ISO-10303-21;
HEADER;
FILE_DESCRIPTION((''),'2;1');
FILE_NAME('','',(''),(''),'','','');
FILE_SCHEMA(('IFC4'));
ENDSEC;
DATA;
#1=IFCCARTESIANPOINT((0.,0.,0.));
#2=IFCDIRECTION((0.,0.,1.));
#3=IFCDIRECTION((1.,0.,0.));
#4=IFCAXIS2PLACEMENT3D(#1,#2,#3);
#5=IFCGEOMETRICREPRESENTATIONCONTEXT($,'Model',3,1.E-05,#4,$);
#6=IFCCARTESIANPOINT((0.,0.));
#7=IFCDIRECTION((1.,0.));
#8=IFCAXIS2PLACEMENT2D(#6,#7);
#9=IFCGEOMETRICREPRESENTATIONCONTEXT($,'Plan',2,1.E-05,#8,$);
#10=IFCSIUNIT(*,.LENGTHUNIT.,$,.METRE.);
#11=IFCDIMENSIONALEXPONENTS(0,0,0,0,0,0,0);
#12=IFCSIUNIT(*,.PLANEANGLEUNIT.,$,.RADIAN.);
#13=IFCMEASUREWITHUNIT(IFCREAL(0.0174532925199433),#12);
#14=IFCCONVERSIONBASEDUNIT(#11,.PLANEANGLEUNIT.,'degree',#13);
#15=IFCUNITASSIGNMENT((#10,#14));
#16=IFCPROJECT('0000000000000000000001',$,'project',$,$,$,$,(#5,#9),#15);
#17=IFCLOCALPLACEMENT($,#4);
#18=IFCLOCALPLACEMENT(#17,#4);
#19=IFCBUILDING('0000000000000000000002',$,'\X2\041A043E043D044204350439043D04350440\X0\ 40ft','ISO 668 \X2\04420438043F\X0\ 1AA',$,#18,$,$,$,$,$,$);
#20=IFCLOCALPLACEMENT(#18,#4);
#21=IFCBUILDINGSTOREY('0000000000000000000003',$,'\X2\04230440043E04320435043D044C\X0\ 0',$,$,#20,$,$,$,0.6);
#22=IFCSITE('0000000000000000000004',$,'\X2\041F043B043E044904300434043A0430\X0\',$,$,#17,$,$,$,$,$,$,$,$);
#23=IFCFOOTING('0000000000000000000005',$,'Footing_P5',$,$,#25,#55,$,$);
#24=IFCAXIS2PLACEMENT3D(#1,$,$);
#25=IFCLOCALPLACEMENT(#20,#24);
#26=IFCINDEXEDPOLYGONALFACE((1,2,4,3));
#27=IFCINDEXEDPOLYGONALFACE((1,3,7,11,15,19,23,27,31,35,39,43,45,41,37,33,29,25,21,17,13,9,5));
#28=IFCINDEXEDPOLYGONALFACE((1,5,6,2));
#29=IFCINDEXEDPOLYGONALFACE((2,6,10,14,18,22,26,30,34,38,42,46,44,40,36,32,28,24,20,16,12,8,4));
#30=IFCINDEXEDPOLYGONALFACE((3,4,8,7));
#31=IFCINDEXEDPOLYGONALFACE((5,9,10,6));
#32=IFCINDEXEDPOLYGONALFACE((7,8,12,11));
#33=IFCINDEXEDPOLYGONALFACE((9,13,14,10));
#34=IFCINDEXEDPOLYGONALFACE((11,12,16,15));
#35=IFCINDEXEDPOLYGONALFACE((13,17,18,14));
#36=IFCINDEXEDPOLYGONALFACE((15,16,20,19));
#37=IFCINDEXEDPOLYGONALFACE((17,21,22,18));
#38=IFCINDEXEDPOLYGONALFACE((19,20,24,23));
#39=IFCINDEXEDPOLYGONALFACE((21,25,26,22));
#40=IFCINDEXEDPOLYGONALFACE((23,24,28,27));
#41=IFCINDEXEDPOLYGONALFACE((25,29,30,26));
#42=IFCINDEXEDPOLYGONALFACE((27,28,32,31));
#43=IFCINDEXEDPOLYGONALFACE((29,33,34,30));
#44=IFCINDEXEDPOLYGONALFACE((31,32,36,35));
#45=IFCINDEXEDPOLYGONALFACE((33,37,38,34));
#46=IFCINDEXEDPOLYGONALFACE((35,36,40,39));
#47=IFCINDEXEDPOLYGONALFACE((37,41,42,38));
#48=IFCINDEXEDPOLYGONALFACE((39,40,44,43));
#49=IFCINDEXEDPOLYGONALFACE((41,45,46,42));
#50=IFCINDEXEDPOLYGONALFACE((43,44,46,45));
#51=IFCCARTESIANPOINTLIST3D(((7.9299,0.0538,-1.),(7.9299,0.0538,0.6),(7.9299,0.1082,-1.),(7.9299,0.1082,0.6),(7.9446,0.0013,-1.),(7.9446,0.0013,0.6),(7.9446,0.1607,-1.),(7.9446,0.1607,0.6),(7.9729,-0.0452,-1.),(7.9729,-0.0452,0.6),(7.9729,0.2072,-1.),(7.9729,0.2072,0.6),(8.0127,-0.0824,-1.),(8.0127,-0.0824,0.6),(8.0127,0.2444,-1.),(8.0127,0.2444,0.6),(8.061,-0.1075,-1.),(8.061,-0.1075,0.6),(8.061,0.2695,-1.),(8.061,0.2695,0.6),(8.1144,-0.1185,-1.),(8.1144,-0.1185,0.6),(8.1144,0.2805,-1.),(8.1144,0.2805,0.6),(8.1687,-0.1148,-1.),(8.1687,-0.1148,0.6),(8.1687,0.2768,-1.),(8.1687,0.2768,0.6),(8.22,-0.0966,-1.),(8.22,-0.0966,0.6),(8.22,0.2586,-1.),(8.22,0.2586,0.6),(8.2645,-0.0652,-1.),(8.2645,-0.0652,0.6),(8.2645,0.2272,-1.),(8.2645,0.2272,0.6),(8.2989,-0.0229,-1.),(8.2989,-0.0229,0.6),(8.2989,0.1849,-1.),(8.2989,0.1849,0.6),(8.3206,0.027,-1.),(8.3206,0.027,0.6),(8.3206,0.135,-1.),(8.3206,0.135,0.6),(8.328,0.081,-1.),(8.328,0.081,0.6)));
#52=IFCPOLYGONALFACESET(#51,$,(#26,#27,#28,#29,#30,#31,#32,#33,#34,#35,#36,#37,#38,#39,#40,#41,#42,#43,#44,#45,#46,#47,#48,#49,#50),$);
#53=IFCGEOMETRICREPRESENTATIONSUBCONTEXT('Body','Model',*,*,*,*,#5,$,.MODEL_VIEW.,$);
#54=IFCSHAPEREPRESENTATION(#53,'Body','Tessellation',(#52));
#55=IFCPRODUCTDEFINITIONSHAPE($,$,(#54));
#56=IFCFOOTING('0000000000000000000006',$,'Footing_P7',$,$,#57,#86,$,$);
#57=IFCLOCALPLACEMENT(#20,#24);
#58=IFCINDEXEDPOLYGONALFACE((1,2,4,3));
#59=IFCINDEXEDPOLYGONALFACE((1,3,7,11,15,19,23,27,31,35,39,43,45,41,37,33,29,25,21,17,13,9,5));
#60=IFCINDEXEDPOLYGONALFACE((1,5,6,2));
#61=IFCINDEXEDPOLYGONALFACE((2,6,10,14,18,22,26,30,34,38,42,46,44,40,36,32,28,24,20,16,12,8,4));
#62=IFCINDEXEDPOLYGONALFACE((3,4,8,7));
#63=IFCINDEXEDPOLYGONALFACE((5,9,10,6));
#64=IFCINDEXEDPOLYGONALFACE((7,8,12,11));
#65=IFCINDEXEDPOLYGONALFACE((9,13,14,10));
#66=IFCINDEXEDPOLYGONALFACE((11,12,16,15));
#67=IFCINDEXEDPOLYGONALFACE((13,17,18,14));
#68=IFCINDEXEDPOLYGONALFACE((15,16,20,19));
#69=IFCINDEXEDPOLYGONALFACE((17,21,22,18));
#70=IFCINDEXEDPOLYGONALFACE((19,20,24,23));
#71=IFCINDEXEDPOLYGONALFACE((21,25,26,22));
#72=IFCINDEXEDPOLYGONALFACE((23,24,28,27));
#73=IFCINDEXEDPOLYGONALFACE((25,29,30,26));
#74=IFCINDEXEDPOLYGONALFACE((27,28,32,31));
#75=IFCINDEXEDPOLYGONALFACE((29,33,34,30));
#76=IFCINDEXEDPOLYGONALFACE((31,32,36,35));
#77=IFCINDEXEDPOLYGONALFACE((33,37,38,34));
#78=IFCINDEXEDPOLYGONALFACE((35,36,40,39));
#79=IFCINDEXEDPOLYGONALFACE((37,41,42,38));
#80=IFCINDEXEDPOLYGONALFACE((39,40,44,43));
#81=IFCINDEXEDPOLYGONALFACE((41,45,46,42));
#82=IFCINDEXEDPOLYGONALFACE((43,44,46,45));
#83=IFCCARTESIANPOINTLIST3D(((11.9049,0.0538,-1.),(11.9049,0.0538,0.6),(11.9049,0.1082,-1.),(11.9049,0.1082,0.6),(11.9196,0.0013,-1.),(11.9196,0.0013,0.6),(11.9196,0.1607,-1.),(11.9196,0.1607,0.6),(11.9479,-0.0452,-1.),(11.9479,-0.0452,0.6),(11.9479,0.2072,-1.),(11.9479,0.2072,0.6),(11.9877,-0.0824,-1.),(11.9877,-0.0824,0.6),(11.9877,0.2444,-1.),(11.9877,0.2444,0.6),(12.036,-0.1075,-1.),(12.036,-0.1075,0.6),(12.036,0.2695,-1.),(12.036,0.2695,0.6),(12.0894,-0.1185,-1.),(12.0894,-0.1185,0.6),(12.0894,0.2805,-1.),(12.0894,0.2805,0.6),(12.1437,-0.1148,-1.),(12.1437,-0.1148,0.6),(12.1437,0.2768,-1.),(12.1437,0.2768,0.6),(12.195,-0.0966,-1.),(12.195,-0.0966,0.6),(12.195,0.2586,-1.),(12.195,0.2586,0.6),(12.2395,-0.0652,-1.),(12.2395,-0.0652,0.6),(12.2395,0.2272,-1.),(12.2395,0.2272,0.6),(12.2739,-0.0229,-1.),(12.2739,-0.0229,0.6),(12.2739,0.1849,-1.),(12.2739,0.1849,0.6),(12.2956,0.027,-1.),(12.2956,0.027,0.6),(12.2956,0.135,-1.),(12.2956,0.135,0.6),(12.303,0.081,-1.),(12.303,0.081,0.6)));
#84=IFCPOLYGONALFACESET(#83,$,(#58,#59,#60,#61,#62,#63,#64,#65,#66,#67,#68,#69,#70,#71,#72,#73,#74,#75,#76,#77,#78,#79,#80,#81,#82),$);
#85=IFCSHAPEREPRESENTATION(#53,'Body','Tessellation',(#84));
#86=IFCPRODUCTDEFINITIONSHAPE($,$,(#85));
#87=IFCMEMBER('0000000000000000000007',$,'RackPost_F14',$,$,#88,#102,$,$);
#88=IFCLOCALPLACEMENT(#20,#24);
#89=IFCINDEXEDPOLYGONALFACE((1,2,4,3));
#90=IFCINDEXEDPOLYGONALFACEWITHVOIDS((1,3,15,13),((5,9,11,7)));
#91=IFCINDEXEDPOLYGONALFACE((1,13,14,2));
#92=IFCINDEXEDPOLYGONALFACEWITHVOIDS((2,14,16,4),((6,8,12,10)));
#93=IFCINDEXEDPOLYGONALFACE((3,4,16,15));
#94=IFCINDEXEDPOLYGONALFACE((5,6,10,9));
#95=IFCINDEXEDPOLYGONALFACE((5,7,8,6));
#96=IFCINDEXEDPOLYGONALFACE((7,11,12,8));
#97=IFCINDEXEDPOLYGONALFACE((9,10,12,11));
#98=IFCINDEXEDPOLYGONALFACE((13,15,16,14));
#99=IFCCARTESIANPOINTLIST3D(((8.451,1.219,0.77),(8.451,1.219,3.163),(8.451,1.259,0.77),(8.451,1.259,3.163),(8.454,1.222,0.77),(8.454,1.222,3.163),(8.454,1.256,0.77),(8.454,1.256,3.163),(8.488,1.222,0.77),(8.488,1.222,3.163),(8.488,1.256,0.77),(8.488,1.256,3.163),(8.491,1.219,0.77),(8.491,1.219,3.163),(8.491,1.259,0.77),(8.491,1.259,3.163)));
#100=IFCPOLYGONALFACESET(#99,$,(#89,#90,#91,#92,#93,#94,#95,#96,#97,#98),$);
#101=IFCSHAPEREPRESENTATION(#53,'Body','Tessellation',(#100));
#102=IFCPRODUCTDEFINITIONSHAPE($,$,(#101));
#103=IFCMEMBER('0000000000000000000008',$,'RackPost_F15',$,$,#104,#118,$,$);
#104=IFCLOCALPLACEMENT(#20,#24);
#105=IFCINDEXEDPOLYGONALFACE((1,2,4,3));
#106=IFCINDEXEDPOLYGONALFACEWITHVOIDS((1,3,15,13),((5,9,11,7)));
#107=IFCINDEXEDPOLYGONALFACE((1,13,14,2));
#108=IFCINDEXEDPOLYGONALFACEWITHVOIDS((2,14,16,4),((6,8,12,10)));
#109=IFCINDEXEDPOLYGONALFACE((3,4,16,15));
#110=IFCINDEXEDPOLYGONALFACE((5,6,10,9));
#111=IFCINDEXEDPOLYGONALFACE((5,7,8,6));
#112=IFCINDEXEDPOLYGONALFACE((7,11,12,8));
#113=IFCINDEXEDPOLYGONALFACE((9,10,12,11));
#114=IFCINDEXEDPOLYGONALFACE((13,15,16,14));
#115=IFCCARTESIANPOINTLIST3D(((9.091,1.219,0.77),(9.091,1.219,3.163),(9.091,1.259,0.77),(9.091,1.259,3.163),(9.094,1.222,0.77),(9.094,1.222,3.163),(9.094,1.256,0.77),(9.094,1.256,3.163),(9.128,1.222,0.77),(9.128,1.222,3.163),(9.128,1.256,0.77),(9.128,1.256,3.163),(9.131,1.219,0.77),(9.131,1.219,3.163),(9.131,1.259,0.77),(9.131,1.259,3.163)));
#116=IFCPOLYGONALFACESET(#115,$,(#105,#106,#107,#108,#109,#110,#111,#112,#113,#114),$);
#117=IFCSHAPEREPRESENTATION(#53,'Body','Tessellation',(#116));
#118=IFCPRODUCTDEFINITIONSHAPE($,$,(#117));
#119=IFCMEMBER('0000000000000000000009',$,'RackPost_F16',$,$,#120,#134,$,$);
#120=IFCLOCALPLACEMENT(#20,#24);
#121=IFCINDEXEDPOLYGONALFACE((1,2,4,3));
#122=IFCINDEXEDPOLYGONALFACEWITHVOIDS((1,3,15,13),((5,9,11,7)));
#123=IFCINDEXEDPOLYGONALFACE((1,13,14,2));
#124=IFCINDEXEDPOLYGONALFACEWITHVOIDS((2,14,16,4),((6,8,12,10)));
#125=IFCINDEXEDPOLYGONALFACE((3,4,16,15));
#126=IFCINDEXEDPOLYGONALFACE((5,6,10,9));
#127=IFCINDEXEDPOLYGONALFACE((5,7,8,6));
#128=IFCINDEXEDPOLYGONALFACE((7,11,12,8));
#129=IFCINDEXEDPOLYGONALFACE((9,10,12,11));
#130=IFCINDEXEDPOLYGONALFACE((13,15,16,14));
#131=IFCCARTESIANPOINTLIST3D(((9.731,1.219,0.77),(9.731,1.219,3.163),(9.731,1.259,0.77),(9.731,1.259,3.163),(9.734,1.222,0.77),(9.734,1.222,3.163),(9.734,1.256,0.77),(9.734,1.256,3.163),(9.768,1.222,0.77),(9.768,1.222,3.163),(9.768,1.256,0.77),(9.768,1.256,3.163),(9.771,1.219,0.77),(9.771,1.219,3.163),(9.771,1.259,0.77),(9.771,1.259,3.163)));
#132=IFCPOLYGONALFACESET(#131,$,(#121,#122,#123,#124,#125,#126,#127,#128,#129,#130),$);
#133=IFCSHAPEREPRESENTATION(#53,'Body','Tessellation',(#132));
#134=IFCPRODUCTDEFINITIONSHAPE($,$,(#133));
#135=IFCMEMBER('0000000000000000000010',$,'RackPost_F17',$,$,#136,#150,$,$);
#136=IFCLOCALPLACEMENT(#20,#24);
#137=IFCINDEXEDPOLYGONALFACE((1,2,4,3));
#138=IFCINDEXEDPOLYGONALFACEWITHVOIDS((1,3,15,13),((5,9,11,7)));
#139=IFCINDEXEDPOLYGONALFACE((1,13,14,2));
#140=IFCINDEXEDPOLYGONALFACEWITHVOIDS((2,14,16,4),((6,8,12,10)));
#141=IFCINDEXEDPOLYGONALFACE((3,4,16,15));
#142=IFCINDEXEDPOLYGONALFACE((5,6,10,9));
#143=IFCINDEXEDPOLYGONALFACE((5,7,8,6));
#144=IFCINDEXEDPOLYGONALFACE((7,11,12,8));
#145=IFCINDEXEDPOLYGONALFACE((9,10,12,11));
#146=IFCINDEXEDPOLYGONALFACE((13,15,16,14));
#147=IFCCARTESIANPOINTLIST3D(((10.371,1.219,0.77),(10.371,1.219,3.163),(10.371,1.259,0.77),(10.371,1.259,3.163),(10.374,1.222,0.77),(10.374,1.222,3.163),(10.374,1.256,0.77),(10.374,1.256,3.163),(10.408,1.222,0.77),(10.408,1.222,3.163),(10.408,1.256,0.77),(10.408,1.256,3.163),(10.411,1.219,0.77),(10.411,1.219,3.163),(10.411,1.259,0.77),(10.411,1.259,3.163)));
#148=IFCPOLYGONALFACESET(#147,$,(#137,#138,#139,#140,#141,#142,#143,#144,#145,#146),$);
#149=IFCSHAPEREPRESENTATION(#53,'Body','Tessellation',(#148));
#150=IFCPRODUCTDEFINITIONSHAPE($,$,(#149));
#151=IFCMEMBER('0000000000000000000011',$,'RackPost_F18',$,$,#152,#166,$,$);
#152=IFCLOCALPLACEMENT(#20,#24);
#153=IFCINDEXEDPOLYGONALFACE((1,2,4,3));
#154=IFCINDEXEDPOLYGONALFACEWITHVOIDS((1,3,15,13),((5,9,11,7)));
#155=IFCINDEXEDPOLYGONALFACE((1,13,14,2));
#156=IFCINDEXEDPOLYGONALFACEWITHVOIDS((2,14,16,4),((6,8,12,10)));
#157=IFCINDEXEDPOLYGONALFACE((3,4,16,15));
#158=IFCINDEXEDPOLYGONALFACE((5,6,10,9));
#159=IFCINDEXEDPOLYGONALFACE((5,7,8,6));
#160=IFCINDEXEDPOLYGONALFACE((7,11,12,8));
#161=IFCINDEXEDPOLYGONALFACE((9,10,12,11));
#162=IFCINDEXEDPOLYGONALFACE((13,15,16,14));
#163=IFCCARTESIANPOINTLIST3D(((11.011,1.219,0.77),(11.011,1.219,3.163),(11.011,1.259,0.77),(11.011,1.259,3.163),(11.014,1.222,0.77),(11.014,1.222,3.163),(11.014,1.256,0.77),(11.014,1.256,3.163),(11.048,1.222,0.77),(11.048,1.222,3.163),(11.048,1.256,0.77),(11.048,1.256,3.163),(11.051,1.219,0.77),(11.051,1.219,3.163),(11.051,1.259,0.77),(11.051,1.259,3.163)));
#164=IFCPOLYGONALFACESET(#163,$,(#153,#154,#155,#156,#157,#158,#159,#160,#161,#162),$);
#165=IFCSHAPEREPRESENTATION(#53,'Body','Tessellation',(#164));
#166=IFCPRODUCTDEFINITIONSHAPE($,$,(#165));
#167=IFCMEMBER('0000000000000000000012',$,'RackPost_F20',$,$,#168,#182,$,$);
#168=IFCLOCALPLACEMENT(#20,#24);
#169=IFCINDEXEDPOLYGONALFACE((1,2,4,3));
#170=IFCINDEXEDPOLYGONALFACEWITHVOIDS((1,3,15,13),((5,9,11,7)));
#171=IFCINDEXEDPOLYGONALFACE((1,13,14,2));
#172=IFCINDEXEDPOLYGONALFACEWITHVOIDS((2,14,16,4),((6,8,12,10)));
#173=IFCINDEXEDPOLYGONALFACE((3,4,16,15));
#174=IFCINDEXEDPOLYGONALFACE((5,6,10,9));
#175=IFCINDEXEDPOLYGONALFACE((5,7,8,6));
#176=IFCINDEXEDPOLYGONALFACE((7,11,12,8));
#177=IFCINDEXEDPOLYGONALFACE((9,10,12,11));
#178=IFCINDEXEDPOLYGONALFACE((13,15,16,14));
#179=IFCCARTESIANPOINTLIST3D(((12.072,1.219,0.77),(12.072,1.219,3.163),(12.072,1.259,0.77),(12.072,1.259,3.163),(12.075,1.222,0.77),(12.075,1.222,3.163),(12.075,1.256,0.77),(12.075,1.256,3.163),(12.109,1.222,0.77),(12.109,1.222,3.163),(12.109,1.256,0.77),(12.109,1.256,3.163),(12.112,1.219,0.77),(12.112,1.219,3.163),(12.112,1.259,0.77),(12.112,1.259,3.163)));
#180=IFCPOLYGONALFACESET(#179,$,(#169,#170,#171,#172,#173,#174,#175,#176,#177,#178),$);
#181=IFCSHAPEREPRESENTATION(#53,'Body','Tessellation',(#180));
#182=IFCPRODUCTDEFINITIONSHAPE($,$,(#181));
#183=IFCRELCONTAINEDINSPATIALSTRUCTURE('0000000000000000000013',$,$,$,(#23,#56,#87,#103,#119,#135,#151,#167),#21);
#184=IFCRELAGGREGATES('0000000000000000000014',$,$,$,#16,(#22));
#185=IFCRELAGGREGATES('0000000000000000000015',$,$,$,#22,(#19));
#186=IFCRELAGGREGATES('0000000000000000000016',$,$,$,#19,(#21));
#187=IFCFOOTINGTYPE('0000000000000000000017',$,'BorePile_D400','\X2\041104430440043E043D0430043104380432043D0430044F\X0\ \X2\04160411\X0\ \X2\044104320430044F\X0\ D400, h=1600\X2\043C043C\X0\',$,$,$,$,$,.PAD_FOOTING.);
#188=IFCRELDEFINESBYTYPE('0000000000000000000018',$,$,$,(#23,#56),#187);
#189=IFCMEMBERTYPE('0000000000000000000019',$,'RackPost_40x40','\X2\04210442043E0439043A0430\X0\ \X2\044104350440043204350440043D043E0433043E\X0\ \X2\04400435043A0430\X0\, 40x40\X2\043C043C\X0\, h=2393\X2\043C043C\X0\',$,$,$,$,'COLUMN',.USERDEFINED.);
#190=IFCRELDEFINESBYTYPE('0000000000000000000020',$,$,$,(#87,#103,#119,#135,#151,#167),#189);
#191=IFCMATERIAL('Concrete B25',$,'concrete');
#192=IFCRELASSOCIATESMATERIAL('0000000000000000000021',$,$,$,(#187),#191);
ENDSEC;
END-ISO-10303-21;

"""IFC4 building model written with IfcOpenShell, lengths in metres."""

from ifc_helpers import new_model, entity, si_unit, converted_unit, frame, origin_with_axes, origin_2d_with_axis, place, context, subcontext, project, spatial, hollow_rectangle, circle, extrude, material, type_object, element, save


model = new_model("IFC4")

# Units and contexts
model_context = context("Model", 3, precision=1e-05, world=origin_with_axes())
plan_context = context("Plan", 2, precision=1e-05, world=origin_2d_with_axis())
body_context = subcontext(model_context, "Body", "Model", "MODEL_VIEW")
ifc_project = project(units=[si_unit("LENGTHUNIT", "METRE"), converted_unit("PLANEANGLEUNIT", "degree", entity("IfcReal", 0.0174532925199433), si_unit("PLANEANGLEUNIT", "RADIAN"), dimensions=[0, 0, 0, 0, 0, 0, 0])], contexts=[model_context, plan_context])

# Site, building, storey
site_placement = place(None, origin_with_axes())
site = spatial("IfcSite", under=ifc_project, at=site_placement, Name="Площадка")
building_placement = place(site_placement, origin_with_axes())
building = spatial("IfcBuilding", under=site, at=building_placement, Name="Контейнер 40ft", Description="ISO 668 тип 1AA")
storey_placement = place(building_placement, origin_with_axes())
storey = spatial("IfcBuildingStorey", under=building, at=storey_placement, Name="Уровень 0", Elevation=0.6)

# Footings
ifc_material = material(Name="Concrete B25", Category="concrete")
footing_type = type_object("IfcFootingType", Name="BorePile_D400", Description="Буронабивная ЖБ свая D400, h=1600мм", PredefinedType="PAD_FOOTING", material=ifc_material)
for number, where, z_axis, x_axis, name in (
    (1, (8.128, 0.081, -1.0), (0.0, 0.0, 1.0), (1.0, 0.0, 0.0), "Footing_P5"),
    (2, (12.103, 0.081, -1.0), (0.0, 0.0, 1.0), (1.0, 0.0, 0.0), "Footing_P7"),
):
    element("IfcFooting", number, at=place(storey_placement, frame(where, z_axis=z_axis, x_axis=x_axis)), inside=storey, type_object=footing_type, Name=name, context=body_context, shape_type="SweptSolid", body=[
        extrude(circle(Radius=0.2), origin_with_axes(), (0.0, 0.0, 1.0), 1.6),
    ])

# Members
member_type = type_object("IfcMemberType", Name="RackPost_40x40", Description="Стойка серверного река, 40x40мм, h=2393мм", ElementType="COLUMN", PredefinedType="USERDEFINED")
for number, where, z_axis, x_axis, name in (
    (3, (8.471, 1.239, 0.77), (0.0, 0.0, 1.0), (1.0, 0.0, 0.0), "RackPost_F14"),
    (4, (9.111, 1.239, 0.77), (0.0, 0.0, 1.0), (1.0, 0.0, 0.0), "RackPost_F15"),
    (5, (9.751, 1.239, 0.77), (0.0, 0.0, 1.0), (1.0, 0.0, 0.0), "RackPost_F16"),
    (6, (10.391, 1.239, 0.77), (0.0, 0.0, 1.0), (1.0, 0.0, 0.0), "RackPost_F17"),
    (7, (11.031, 1.239, 0.77), (0.0, 0.0, 1.0), (1.0, 0.0, 0.0), "RackPost_F18"),
    (8, (12.092, 1.239, 0.77), (0.0, 0.0, 1.0), (1.0, 0.0, 0.0), "RackPost_F20"),
):
    element("IfcMember", number, at=place(storey_placement, frame(where, z_axis=z_axis, x_axis=x_axis)), inside=storey, type_object=member_type, Name=name, context=body_context, shape_type="SweptSolid", body=[
        extrude(hollow_rectangle(XDim=0.04, YDim=0.04, WallThickness=0.003), origin_with_axes(), (0.0, 0.0, 1.0), 2.393),
    ])

save(model, "model.ifc")
